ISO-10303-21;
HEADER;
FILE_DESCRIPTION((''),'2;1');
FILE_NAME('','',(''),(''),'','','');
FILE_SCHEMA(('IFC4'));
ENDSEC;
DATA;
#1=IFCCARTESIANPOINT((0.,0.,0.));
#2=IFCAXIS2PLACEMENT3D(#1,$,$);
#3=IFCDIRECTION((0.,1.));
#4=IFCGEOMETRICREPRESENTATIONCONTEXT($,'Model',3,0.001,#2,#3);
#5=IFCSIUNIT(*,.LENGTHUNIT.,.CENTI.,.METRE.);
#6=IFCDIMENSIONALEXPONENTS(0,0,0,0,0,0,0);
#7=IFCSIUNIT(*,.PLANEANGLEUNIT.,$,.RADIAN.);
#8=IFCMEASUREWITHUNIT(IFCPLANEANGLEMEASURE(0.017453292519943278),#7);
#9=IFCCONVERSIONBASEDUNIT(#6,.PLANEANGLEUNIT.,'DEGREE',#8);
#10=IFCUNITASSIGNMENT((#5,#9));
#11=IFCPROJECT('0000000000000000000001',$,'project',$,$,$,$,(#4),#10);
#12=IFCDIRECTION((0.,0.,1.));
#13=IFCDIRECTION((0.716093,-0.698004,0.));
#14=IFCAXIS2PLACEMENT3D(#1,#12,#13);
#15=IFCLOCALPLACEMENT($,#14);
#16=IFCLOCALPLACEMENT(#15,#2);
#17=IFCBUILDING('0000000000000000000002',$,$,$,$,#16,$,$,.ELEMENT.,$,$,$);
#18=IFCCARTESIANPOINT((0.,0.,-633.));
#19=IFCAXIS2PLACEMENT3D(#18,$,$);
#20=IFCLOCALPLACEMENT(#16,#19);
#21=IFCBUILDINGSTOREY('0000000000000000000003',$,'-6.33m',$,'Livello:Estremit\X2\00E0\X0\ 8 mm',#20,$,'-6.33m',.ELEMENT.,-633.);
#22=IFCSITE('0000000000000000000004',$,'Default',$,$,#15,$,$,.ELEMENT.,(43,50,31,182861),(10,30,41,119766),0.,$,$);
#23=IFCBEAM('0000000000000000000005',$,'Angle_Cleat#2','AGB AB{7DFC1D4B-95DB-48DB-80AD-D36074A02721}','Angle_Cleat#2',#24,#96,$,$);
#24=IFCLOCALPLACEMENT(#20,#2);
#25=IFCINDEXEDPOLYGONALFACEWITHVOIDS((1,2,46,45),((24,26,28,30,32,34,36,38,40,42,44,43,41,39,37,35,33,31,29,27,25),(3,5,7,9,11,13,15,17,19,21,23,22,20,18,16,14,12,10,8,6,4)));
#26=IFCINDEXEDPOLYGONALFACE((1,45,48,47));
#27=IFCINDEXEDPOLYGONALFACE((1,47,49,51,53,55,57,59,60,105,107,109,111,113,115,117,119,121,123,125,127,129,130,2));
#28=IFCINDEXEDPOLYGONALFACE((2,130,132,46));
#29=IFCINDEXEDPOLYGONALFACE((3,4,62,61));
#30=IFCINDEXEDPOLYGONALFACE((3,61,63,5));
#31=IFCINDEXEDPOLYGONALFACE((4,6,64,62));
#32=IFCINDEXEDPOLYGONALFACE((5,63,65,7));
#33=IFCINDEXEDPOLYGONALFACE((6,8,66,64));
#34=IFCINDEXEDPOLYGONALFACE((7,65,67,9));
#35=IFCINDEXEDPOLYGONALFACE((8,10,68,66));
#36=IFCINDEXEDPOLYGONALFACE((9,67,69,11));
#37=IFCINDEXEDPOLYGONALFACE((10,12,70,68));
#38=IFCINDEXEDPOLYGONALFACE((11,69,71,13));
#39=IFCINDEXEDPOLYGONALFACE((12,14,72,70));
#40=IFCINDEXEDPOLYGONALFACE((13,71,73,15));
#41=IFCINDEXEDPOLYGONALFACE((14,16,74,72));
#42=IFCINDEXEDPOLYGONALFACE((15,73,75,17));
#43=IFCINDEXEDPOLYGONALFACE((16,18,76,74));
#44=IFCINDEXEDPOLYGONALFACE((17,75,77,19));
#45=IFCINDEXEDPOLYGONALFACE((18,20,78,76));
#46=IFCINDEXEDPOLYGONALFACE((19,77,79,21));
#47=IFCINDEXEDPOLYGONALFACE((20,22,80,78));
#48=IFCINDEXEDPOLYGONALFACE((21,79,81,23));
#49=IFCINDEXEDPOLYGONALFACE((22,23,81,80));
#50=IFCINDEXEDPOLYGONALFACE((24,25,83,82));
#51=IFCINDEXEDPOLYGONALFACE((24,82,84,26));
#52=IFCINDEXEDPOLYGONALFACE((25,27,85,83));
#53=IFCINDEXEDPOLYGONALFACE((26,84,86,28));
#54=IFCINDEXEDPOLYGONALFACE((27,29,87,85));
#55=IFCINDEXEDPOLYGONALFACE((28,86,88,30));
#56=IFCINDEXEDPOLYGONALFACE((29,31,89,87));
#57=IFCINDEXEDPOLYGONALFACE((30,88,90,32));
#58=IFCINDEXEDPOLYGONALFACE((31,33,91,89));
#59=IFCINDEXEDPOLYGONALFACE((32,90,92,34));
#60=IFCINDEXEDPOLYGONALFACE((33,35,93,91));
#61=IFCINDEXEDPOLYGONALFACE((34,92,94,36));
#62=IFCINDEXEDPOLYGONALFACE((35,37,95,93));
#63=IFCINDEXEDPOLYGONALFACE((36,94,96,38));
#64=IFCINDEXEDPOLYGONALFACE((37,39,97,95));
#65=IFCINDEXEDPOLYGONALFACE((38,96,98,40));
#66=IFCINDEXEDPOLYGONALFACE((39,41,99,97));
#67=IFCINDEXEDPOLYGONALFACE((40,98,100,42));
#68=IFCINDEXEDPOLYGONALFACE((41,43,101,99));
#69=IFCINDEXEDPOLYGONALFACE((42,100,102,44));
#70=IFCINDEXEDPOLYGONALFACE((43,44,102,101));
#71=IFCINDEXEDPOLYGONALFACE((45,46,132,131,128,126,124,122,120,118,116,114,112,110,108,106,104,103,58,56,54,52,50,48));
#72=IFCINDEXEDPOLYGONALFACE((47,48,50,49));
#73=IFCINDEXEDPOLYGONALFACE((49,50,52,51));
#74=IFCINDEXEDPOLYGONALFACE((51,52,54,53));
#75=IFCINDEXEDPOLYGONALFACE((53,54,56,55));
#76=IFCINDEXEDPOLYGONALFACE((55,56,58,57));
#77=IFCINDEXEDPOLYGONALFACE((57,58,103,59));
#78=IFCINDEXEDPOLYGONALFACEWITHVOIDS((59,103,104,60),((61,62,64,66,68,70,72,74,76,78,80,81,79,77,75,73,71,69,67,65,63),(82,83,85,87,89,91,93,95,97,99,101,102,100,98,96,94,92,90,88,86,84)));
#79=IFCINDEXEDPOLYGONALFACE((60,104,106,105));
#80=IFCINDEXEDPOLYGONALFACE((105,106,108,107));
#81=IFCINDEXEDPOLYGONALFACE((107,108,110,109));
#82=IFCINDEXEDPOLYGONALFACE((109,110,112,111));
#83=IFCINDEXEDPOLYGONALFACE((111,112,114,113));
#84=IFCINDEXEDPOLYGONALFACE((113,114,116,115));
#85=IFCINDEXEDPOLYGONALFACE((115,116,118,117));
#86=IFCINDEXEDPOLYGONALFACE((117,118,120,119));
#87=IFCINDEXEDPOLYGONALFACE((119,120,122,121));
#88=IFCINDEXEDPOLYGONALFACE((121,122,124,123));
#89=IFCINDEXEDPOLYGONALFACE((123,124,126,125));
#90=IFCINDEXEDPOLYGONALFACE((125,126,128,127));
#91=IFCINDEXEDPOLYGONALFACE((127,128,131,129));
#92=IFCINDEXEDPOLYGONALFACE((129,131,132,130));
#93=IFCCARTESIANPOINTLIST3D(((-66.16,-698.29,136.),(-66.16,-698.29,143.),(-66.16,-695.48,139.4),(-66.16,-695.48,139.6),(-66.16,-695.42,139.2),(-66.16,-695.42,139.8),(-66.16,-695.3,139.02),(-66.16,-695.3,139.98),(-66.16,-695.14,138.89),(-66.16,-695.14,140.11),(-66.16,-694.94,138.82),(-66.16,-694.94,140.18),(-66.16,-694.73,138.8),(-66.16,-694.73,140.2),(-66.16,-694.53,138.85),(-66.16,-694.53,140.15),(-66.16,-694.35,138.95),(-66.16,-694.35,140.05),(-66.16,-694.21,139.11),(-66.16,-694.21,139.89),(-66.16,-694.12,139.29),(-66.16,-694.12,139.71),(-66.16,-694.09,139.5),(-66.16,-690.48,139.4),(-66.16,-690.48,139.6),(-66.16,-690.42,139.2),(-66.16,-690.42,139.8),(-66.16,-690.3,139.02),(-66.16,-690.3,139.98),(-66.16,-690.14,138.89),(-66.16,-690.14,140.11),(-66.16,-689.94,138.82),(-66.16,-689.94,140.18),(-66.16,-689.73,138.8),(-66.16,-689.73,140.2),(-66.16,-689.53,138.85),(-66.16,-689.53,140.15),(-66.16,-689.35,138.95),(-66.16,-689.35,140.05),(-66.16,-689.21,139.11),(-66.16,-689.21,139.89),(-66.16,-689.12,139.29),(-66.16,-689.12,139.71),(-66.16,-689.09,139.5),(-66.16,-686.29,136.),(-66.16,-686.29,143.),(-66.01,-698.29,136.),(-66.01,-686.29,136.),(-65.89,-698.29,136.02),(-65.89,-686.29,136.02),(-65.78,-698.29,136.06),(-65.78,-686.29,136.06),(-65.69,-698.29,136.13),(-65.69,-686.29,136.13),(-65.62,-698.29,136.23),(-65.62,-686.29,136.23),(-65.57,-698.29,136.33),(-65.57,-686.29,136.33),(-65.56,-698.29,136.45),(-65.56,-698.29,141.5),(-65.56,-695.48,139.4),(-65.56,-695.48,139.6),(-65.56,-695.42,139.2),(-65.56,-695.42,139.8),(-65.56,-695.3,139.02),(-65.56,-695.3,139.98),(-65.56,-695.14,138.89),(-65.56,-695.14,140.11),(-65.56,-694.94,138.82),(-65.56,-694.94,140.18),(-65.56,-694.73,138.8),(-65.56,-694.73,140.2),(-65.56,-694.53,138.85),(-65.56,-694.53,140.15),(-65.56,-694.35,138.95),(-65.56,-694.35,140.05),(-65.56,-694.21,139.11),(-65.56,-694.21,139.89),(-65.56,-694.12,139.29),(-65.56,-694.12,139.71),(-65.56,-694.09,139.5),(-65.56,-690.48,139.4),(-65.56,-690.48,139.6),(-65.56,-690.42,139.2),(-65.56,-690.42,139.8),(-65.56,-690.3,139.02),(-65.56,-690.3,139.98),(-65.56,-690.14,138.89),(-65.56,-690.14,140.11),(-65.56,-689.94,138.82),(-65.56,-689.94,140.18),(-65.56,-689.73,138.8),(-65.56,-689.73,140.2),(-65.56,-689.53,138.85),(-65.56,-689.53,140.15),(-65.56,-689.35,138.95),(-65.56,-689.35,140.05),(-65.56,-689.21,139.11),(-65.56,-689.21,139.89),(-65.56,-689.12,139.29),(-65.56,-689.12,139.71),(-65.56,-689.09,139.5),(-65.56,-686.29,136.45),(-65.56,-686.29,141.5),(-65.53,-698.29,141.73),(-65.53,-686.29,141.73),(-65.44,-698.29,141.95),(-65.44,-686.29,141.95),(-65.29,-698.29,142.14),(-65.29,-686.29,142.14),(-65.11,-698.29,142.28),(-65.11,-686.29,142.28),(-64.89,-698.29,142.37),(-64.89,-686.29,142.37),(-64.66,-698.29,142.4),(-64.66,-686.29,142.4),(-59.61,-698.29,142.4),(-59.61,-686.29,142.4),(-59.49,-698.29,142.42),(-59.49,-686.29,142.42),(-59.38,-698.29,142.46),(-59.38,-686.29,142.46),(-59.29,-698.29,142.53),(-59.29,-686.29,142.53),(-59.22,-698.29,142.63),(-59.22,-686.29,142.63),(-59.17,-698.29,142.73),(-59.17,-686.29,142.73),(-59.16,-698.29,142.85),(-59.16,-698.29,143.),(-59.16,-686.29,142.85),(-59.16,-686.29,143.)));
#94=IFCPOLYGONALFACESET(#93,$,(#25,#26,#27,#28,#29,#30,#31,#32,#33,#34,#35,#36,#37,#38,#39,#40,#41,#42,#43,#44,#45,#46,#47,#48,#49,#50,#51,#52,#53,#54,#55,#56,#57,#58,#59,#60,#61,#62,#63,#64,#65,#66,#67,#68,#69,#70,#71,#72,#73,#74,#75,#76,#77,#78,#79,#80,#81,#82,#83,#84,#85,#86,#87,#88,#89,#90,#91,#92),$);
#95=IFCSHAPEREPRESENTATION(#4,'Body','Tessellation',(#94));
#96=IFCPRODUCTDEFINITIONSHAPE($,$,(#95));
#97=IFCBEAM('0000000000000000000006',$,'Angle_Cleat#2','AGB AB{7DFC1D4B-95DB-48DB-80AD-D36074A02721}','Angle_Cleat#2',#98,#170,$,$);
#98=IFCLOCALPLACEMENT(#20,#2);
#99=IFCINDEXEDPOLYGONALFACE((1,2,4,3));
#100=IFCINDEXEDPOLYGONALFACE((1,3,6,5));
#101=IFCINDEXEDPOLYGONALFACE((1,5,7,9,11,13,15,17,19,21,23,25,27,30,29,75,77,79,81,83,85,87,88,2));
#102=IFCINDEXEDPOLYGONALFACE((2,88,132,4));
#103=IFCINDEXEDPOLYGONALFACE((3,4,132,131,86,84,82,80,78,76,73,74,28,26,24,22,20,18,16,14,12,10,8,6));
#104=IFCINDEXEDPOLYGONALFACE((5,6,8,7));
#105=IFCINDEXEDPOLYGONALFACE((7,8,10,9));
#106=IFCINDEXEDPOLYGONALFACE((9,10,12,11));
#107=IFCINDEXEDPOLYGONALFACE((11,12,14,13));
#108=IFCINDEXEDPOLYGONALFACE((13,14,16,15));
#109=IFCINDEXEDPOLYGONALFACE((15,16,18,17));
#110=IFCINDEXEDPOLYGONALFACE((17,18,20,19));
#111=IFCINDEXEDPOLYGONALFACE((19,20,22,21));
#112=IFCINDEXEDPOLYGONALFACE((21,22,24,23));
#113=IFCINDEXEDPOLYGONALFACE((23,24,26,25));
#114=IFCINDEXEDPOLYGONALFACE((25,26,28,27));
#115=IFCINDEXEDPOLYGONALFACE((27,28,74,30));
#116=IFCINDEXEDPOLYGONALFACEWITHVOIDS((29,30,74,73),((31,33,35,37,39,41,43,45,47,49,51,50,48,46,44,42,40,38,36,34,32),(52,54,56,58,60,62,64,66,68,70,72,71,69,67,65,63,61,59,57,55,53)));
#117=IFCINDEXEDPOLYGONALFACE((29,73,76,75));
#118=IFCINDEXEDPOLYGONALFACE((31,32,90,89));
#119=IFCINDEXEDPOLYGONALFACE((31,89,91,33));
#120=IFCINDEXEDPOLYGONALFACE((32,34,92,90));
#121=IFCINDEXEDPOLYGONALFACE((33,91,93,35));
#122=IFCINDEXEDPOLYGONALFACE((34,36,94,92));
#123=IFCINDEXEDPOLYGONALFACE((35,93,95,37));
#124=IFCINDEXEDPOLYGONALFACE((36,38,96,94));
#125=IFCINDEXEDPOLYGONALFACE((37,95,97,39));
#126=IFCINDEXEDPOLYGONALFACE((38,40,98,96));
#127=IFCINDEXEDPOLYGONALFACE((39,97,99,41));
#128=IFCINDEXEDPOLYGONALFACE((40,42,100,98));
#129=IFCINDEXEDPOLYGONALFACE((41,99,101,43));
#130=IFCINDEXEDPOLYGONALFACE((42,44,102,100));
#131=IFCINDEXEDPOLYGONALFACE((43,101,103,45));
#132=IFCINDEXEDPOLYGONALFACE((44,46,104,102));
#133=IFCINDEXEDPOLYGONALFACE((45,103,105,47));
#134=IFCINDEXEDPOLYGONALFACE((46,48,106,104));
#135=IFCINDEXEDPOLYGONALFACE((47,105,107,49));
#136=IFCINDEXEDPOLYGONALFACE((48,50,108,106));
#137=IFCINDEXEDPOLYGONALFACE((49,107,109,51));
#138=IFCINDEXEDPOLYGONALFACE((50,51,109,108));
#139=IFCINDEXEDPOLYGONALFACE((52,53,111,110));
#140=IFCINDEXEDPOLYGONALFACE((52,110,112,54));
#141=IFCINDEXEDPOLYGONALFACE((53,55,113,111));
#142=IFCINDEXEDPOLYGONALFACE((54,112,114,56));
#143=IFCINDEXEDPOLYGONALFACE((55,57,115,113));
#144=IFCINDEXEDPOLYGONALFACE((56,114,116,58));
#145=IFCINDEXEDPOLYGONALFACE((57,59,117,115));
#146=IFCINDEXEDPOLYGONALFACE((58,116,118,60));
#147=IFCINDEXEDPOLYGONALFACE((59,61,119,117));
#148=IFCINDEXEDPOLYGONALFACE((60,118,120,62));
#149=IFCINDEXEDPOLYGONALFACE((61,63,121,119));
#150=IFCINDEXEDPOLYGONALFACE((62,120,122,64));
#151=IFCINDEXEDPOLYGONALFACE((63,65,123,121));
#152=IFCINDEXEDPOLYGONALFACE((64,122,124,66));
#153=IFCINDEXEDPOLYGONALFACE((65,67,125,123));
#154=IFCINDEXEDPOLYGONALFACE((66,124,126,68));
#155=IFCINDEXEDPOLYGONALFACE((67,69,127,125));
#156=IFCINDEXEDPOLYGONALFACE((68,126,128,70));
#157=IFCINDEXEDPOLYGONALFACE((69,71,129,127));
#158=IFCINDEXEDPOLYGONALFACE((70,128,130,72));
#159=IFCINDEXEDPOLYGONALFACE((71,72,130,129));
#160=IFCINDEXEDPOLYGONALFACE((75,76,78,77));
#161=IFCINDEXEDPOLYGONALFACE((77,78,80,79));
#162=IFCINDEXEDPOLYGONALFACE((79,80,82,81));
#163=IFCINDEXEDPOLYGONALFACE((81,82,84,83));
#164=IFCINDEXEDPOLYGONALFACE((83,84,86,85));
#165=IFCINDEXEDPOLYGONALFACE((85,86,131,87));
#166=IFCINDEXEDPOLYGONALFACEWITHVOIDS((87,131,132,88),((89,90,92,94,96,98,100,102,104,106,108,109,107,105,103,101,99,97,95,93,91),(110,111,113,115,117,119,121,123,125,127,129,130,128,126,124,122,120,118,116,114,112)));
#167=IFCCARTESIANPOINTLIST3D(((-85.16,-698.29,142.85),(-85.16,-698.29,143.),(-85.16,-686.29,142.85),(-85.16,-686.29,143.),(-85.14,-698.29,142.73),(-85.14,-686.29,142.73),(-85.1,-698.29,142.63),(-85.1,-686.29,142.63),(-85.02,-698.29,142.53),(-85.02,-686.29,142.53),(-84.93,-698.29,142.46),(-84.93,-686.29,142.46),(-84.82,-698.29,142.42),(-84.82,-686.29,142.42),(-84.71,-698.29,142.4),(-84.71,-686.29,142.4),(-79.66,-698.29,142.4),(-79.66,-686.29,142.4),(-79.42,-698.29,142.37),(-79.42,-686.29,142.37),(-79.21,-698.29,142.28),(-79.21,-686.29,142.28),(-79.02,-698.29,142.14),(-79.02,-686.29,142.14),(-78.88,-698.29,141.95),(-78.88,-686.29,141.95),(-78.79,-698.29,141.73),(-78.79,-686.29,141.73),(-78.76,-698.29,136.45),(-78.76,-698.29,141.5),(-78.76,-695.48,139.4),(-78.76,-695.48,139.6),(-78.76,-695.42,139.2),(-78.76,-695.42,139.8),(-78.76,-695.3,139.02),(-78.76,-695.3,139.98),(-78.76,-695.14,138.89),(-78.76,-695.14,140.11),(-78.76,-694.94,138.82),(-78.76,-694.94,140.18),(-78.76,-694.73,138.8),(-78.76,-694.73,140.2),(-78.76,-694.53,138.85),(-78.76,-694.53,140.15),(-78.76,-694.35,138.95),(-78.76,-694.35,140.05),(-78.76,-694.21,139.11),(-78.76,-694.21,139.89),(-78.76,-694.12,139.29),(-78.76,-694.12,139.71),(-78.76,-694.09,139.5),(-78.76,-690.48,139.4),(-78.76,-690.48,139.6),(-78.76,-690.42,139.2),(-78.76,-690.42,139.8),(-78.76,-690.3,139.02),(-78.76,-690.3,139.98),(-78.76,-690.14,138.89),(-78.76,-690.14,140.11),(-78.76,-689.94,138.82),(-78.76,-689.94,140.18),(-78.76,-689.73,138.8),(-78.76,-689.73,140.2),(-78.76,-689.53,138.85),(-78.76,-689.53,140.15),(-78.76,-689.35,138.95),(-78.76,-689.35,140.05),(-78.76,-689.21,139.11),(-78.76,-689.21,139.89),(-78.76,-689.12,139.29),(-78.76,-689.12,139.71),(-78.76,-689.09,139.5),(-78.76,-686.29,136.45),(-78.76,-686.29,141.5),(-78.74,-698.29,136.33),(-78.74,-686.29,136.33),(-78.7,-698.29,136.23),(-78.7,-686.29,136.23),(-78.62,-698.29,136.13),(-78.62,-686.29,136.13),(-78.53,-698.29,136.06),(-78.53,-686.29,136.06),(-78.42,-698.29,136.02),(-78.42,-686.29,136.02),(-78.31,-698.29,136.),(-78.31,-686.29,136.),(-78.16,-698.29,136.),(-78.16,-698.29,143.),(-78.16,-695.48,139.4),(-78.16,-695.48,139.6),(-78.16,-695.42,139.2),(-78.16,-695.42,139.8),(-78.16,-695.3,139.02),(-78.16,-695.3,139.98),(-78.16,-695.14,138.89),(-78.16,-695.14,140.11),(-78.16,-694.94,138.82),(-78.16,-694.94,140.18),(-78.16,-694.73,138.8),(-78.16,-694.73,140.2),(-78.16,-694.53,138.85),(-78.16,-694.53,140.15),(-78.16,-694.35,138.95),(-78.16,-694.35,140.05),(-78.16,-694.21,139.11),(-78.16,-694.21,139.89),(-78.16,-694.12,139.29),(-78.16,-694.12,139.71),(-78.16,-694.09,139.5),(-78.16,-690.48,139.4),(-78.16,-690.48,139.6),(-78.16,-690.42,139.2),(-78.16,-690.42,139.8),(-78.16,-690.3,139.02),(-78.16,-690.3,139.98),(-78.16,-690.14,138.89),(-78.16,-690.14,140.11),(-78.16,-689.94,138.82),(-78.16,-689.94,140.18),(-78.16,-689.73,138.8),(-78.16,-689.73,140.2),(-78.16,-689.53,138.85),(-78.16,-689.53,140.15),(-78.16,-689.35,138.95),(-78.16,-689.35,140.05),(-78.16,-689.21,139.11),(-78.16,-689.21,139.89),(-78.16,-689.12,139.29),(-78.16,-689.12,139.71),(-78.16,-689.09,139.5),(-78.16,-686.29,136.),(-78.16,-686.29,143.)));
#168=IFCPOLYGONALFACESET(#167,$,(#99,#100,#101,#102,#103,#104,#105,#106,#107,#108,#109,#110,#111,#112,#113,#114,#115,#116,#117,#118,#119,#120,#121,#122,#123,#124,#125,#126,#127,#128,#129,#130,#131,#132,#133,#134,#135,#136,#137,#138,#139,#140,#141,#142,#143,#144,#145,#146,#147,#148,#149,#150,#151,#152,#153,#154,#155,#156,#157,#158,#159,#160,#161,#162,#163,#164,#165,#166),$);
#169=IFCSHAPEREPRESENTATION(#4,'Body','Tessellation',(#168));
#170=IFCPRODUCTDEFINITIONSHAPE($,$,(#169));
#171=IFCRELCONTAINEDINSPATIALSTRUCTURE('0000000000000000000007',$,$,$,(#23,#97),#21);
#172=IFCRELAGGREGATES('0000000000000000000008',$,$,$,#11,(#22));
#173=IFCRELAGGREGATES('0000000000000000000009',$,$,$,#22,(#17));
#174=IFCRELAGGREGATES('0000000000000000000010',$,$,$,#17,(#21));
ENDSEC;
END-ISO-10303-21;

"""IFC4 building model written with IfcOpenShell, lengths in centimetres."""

from ifc_helpers import new_model, entity, si_unit, converted_unit, direction, frame, frame_2d, origin, place, context, project, spatial, circle, l_section, extrude, element, save


model = new_model("IFC4")

# Units and contexts
model_context = context("Model", 3, precision=0.001, world=origin(), true_north=direction((0.0, 1.0)))
ifc_project = project(units=[si_unit("LENGTHUNIT", "METRE", prefix="CENTI"), converted_unit("PLANEANGLEUNIT", "DEGREE", entity("IfcPlaneAngleMeasure", 0.017453292519943278), si_unit("PLANEANGLEUNIT", "RADIAN"), dimensions=[0, 0, 0, 0, 0, 0, 0])], contexts=[model_context])

# Site, building, storey
site_placement = place(None, frame((0.0, 0.0, 0.0), z_axis=(0.0, 0.0, 1.0), x_axis=(0.716093, -0.698004, 0.0)))
site = spatial("IfcSite", under=ifc_project, at=site_placement, Name="Default", CompositionType="ELEMENT", RefLatitude=(43, 50, 31, 182861), RefLongitude=(10, 30, 41, 119766), RefElevation=0.0)
building_placement = place(site_placement, origin())
building = spatial("IfcBuilding", under=site, at=building_placement, CompositionType="ELEMENT")
storey_placement = place(building_placement, frame((0.0, 0.0, -633.0)))
storey = spatial("IfcBuildingStorey", under=building, at=storey_placement, Name="-6.33m", ObjectType="Livello:Estremità 8 mm", LongName="-6.33m", CompositionType="ELEMENT", Elevation=-633.0)

# Beams, openings
beam_1_placement = place(storey_placement, frame((-64.23, -686.29, 141.07), z_axis=(0.0, 1.0, 0.0), x_axis=(1.0, 0.0, 0.0)))
beam_1 = element("IfcBeam", 1, at=beam_1_placement, inside=storey, Name="Angle_Cleat#2", Description="AGB AB{7DFC1D4B-95DB-48DB-80AD-D36074A02721}", ObjectType="Angle_Cleat#2", context=model_context, shape_type="SweptSolid", body=[
    extrude(l_section(Depth=7.0, Width=7.0, Thickness=0.6, FilletRadius=0.9, EdgeRadius=0.45, at=frame_2d((1.57, 1.57))), origin(), (0.0, 0.0, -1.0), 12.0),
])
opening_1_placement = place(beam_1_placement, frame((-1.98, 1.57, -6.0), z_axis=(1.0, 0.0, 0.0), x_axis=(0.0, 0.0, 1.0)))
element("IfcOpeningElement", 2, at=opening_1_placement, cuts=beam_1, ObjectType="Opening", context=model_context, shape_type="SweptSolid", body=[
    extrude(circle(Radius=0.7, at=frame_2d((2.5, 0.0), x_axis=(1.0, 0.0))), origin(), (0.0, 0.0, 1.0), 0.7),
])
opening_2_placement = place(beam_1_placement, frame((-1.98, 1.57, -6.0), z_axis=(1.0, 0.0, 0.0), x_axis=(0.0, 0.0, 1.0)))
element("IfcOpeningElement", 3, at=opening_2_placement, cuts=beam_1, ObjectType="Opening", context=model_context, shape_type="SweptSolid", body=[
    extrude(circle(Radius=0.7, at=frame_2d((-2.5, 0.0), x_axis=(1.0, 0.0))), origin(), (0.0, 0.0, 1.0), 0.7),
])
beam_2_placement = place(storey_placement, frame((-80.09, -698.29, 141.07), z_axis=(0.0, -1.0, 0.0), x_axis=(-1.0, 0.0, 0.0)))
beam_2 = element("IfcBeam", 4, at=beam_2_placement, inside=storey, Name="Angle_Cleat#2", Description="AGB AB{7DFC1D4B-95DB-48DB-80AD-D36074A02721}", ObjectType="Angle_Cleat#2", context=model_context, shape_type="SweptSolid", body=[
    extrude(l_section(Depth=7.0, Width=7.0, Thickness=0.6, FilletRadius=0.9, EdgeRadius=0.45, at=frame_2d((1.57, 1.57))), origin(), (0.0, 0.0, -1.0), 12.0),
])
opening_3_placement = place(beam_2_placement, frame((-1.28, 1.57, -6.0), z_axis=(-1.0, 0.0, 0.0), x_axis=(0.0, 0.0, -1.0)))
element("IfcOpeningElement", 5, at=opening_3_placement, cuts=beam_2, ObjectType="Opening", context=model_context, shape_type="SweptSolid", body=[
    extrude(circle(Radius=0.7, at=frame_2d((2.5, 0.0), x_axis=(1.0, 0.0))), origin(), (0.0, 0.0, 1.0), 0.7),
])
opening_4_placement = place(beam_2_placement, frame((-1.28, 1.57, -6.0), z_axis=(-1.0, 0.0, 0.0), x_axis=(0.0, 0.0, -1.0)))
element("IfcOpeningElement", 6, at=opening_4_placement, cuts=beam_2, ObjectType="Opening", context=model_context, shape_type="SweptSolid", body=[
    extrude(circle(Radius=0.7, at=frame_2d((-2.5, 0.0), x_axis=(1.0, 0.0))), origin(), (0.0, 0.0, 1.0), 0.7),
])

save(model, "model.ifc")
